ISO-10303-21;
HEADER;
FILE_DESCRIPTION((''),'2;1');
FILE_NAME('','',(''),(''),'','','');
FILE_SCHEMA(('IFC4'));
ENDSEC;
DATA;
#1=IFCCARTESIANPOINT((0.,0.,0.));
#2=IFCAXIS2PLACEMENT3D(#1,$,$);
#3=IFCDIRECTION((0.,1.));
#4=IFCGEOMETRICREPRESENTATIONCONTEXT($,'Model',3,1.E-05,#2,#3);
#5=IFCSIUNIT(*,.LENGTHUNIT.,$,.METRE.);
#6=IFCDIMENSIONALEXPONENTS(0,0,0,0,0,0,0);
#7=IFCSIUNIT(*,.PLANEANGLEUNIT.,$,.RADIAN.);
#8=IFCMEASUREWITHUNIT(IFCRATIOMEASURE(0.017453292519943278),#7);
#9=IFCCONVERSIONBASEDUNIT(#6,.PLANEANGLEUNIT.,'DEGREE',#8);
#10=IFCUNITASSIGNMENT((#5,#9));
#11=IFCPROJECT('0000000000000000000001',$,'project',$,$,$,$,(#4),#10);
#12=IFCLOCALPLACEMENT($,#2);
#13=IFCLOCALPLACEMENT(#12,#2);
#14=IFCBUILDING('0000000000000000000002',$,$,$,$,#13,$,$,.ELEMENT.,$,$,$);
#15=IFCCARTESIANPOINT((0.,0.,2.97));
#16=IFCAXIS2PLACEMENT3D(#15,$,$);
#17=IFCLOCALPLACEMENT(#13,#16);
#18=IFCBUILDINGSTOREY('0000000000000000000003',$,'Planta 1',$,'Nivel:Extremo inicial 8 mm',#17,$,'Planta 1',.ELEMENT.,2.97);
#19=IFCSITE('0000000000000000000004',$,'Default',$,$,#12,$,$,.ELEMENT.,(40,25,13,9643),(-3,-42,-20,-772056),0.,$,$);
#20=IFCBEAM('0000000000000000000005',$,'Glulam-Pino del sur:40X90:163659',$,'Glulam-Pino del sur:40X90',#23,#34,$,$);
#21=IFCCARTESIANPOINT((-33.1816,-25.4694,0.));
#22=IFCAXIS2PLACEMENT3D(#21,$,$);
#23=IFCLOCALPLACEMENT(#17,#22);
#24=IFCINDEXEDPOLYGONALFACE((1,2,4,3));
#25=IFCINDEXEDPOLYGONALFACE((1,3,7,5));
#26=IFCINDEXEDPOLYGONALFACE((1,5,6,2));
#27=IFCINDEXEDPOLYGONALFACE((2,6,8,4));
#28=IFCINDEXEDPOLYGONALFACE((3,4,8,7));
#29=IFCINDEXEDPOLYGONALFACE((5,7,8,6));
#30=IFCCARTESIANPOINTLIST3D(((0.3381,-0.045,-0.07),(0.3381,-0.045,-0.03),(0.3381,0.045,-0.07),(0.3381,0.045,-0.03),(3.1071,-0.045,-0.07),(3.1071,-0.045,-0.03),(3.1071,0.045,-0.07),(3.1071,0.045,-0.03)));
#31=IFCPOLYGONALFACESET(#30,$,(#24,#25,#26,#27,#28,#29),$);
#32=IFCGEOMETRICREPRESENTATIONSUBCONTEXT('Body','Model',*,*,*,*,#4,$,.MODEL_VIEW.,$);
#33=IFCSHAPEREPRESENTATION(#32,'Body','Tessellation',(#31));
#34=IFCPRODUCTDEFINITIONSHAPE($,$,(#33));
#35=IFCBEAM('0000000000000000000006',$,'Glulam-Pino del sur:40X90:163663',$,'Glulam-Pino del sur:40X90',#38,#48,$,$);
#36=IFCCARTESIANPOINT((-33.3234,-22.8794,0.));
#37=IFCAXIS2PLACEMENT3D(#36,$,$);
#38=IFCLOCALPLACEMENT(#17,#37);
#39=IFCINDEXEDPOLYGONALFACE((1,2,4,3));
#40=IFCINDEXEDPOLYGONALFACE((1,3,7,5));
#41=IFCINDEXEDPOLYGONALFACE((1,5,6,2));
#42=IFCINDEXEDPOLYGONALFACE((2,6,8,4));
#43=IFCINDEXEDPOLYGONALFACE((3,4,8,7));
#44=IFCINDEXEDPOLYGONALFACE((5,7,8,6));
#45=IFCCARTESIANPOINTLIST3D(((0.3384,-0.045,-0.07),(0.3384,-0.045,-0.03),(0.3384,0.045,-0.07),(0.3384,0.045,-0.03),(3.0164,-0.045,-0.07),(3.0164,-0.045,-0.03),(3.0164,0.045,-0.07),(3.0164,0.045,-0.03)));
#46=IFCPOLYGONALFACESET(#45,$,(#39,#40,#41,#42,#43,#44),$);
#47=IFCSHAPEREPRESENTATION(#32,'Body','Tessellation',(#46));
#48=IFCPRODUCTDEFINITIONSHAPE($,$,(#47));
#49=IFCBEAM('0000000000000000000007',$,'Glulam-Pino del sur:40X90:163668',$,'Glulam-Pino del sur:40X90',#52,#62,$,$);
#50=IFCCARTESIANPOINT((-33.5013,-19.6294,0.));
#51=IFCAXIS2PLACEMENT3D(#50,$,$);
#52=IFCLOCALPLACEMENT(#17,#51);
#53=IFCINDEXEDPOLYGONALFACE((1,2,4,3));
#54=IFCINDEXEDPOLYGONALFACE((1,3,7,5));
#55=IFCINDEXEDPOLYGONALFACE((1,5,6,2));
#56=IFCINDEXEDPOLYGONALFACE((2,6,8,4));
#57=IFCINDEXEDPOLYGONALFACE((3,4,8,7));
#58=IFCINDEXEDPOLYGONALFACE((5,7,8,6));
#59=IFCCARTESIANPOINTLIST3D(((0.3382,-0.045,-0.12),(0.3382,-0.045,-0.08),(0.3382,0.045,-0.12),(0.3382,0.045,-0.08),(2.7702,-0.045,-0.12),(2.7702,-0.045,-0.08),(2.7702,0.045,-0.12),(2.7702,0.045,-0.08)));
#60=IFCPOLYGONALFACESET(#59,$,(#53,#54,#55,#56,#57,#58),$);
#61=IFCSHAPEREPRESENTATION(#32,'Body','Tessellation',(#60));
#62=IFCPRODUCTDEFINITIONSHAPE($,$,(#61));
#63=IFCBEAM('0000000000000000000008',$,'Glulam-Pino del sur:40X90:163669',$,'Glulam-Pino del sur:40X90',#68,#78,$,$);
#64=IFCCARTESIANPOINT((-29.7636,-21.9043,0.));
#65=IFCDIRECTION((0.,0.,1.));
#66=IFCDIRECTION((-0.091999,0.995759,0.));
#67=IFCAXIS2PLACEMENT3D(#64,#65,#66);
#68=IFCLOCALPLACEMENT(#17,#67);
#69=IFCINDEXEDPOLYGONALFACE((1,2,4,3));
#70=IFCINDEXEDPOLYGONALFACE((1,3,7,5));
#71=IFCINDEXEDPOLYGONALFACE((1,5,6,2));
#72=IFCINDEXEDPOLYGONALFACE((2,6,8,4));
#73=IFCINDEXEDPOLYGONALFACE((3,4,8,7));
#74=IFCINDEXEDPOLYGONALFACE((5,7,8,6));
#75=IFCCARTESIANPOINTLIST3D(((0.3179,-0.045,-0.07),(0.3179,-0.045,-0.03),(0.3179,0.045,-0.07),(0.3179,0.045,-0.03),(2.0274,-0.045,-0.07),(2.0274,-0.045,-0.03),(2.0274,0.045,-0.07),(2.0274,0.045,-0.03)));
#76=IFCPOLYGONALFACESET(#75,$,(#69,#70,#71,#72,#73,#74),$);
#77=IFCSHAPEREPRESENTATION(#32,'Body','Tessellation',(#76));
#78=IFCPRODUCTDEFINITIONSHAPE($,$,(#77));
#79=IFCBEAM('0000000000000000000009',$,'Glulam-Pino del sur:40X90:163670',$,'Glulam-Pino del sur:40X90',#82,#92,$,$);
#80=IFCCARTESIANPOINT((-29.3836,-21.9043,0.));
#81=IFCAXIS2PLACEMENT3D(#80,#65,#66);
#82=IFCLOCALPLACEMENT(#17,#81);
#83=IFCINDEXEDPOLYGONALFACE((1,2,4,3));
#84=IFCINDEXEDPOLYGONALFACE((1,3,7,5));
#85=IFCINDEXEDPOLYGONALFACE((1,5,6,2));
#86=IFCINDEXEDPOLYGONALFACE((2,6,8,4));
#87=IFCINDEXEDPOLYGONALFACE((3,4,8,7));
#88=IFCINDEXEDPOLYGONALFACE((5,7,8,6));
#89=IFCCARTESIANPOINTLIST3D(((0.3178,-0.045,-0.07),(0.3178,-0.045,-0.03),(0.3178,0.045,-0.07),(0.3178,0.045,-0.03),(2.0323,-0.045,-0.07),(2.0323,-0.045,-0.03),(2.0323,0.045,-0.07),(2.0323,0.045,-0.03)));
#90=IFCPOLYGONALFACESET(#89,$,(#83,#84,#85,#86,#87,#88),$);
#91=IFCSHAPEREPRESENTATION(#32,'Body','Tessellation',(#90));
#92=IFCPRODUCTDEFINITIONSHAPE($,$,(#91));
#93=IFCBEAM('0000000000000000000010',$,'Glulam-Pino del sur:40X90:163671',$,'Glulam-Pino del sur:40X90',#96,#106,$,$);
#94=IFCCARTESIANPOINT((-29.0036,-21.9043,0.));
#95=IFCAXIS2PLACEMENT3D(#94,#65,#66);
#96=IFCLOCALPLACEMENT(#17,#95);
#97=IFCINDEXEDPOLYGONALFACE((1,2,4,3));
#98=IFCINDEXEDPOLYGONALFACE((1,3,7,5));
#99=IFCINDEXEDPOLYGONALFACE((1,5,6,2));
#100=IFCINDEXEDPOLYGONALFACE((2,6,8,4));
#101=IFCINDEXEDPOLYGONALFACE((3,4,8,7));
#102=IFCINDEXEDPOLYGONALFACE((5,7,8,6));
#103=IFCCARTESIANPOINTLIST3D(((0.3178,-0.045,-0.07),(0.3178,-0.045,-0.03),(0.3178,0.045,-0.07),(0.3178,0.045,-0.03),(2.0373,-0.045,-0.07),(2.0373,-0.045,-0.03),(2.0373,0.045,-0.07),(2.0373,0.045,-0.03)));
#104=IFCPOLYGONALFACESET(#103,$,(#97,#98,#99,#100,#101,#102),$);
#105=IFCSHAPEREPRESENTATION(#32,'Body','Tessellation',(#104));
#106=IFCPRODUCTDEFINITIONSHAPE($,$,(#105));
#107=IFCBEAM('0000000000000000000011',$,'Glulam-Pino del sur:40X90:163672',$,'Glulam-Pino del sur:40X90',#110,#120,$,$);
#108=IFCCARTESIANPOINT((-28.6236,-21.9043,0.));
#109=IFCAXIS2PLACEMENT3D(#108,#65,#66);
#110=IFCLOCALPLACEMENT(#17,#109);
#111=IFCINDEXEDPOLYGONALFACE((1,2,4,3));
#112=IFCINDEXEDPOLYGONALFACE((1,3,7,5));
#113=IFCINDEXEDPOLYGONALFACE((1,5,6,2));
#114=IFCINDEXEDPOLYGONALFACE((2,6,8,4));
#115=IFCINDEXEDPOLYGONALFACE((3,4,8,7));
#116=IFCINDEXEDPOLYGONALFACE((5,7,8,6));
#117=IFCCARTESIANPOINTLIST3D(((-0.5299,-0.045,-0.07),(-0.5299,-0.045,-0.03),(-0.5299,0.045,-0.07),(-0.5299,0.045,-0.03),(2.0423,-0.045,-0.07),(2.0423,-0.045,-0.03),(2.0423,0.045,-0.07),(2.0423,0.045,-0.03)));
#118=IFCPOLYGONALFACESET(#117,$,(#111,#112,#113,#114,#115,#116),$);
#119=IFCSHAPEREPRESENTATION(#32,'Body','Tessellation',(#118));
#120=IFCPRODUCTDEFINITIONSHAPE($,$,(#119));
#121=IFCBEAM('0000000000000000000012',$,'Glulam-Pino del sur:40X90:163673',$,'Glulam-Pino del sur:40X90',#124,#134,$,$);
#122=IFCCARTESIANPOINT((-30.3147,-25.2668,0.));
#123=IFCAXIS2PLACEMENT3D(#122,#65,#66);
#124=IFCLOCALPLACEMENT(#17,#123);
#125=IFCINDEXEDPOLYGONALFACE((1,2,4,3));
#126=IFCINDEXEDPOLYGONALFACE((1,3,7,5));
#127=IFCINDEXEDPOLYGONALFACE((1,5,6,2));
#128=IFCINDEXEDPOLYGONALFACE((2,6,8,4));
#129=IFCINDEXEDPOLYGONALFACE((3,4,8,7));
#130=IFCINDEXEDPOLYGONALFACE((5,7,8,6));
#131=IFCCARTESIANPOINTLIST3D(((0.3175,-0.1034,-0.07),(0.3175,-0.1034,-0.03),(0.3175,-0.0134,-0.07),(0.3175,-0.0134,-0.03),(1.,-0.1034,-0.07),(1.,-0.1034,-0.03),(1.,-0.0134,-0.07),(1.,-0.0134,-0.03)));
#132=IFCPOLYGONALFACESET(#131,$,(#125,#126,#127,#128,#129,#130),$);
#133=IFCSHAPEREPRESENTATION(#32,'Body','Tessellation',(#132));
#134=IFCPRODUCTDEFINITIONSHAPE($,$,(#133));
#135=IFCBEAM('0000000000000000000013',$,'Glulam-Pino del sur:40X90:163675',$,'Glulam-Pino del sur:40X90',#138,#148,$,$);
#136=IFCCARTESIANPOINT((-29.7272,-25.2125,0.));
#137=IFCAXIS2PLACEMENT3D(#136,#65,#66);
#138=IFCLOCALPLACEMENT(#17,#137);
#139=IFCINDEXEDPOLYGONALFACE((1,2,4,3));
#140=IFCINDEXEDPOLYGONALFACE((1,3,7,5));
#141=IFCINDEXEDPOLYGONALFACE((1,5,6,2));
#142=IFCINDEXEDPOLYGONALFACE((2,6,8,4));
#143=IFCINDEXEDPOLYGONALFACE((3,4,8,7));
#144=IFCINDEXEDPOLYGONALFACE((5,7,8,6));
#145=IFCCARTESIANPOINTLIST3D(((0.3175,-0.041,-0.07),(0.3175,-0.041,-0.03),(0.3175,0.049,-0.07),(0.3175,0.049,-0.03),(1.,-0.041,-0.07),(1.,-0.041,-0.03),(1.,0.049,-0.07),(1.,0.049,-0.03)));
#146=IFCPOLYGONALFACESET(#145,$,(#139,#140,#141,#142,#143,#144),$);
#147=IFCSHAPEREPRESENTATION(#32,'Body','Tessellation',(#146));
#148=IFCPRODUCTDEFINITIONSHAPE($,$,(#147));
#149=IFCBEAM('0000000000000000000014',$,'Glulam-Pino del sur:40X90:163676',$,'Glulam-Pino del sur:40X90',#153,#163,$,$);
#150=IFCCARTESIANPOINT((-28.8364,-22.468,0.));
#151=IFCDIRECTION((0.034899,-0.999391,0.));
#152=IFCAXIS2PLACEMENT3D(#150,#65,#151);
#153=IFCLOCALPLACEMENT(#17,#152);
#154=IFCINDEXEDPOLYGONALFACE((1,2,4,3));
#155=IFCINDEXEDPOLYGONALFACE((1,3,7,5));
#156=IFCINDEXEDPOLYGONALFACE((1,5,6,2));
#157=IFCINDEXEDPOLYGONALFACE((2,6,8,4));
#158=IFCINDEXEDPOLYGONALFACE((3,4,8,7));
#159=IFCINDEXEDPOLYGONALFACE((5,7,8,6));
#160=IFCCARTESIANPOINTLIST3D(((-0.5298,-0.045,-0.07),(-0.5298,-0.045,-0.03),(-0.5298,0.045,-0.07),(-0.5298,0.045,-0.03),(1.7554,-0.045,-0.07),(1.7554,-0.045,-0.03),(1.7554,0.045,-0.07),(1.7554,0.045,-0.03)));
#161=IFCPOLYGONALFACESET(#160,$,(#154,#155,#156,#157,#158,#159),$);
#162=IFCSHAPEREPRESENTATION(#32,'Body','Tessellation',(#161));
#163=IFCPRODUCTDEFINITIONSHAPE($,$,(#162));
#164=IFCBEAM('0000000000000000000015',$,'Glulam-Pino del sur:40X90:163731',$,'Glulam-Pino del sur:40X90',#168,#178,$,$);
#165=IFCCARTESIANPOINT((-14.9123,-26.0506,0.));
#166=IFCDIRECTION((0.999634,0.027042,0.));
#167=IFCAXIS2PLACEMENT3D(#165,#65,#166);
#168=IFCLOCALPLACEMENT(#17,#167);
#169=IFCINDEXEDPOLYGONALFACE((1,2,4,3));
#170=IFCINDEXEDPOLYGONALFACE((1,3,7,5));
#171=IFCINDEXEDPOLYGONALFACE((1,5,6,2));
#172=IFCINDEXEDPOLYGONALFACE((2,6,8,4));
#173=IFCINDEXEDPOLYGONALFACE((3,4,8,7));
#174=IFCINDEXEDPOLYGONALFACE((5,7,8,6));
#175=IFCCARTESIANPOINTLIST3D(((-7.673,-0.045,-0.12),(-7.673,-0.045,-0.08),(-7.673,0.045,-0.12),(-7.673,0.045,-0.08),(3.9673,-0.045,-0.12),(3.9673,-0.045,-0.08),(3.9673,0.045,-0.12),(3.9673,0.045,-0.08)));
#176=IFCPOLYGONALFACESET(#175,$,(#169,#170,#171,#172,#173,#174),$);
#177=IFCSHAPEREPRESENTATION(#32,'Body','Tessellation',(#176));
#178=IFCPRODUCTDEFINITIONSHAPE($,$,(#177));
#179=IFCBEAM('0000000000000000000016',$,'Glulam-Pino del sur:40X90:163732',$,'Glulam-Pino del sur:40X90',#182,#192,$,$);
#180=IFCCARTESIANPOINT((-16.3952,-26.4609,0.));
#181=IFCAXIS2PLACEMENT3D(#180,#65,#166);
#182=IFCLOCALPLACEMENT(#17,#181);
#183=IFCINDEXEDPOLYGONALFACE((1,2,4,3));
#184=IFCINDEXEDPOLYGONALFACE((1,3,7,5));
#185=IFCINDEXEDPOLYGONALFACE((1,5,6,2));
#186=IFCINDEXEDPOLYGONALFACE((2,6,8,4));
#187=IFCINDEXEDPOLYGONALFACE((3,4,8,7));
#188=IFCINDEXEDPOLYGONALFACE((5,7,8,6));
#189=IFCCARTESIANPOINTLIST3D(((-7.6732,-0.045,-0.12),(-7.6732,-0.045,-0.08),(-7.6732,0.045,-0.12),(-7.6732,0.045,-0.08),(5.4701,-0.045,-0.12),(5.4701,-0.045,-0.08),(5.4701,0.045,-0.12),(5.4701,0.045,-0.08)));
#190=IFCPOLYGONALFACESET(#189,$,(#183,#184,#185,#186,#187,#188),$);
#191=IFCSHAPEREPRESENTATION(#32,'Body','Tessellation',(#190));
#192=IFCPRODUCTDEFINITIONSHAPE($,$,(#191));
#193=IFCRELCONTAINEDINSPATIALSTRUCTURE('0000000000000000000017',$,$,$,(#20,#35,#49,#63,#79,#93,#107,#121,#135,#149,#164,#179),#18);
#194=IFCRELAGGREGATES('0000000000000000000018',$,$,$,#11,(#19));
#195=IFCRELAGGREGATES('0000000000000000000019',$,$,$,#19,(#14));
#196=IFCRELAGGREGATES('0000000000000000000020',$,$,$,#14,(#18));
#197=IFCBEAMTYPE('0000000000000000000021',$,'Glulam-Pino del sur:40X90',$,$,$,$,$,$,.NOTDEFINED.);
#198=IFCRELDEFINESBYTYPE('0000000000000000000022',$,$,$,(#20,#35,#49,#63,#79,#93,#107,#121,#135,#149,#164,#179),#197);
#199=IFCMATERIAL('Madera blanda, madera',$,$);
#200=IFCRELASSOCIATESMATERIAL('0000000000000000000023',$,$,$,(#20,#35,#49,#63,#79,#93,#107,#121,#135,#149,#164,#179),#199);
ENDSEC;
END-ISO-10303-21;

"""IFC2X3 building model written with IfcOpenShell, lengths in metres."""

from ifc_helpers import new_model, entity, si_unit, converted_unit, direction, frame, frame_2d, origin, place, context, subcontext, project, spatial, rectangle, extrude, material, type_object, element, save


model = new_model("IFC2X3")

# Units and contexts
model_context = context("Model", 3, precision=1e-05, world=origin(), true_north=direction((0.0, 1.0)))
body_context = subcontext(model_context, "Body", "Model", "MODEL_VIEW")
ifc_project = project(units=[si_unit("LENGTHUNIT", "METRE"), converted_unit("PLANEANGLEUNIT", "DEGREE", entity("IfcRatioMeasure", 0.017453292519943278), si_unit("PLANEANGLEUNIT", "RADIAN"), dimensions=[0, 0, 0, 0, 0, 0, 0])], contexts=[model_context])

# Site, building, storey
site_placement = place(None, origin())
site = spatial("IfcSite", under=ifc_project, at=site_placement, Name="Default", CompositionType="ELEMENT", RefLatitude=(40, 25, 13, 9643), RefLongitude=(-3, -42, -20, -772056), RefElevation=0.0)
building_placement = place(site_placement, origin())
building = spatial("IfcBuilding", under=site, at=building_placement, CompositionType="ELEMENT")
storey_placement = place(building_placement, frame((0.0, 0.0, 2.97)))
storey = spatial("IfcBuildingStorey", under=building, at=storey_placement, Name="Planta 1", ObjectType="Nivel:Extremo inicial 8 mm", LongName="Planta 1", CompositionType="ELEMENT", Elevation=2.97)

# Beams
ifc_material_1 = material(Name="Madera blanda, madera")
beam_type_1 = type_object("IfcBeamType", Name="Glulam-Pino del sur:40X90", PredefinedType="NOTDEFINED")
beam_1_placement = place(storey_placement, frame((-33.1816, -25.4694, 0.0)))
element("IfcBeam", 1, at=beam_1_placement, inside=storey, type_object=beam_type_1, material=ifc_material_1, Name="Glulam-Pino del sur:40X90:163659", ObjectType="Glulam-Pino del sur:40X90", context=body_context, shape_type="SweptSolid", body=[
    extrude(rectangle(XDim=0.04, YDim=0.09, at=frame_2d((0.0, 0.0), x_axis=(1.0, 0.0))), frame((0.3381, 0.0, -0.05), z_axis=(1.0, 0.0, 0.0), x_axis=(0.0, 0.0, -1.0)), (0.0, 0.0, 1.0), 2.769),
])
beam_2_placement = place(storey_placement, frame((-33.3234, -22.8794, 0.0)))
element("IfcBeam", 2, at=beam_2_placement, inside=storey, type_object=beam_type_1, material=ifc_material_1, Name="Glulam-Pino del sur:40X90:163663", ObjectType="Glulam-Pino del sur:40X90", context=body_context, shape_type="SweptSolid", body=[
    extrude(rectangle(XDim=0.04, YDim=0.09, at=frame_2d((0.0, 0.0), x_axis=(1.0, 0.0))), frame((0.3384, 0.0, -0.05), z_axis=(1.0, 0.0, 0.0), x_axis=(0.0, 0.0, -1.0)), (0.0, 0.0, 1.0), 2.678),
])
beam_3_placement = place(storey_placement, frame((-33.5013, -19.6294, 0.0)))
element("IfcBeam", 3, at=beam_3_placement, inside=storey, type_object=beam_type_1, material=ifc_material_1, Name="Glulam-Pino del sur:40X90:163668", ObjectType="Glulam-Pino del sur:40X90", context=body_context, shape_type="SweptSolid", body=[
    extrude(rectangle(XDim=0.04, YDim=0.09, at=frame_2d((0.0, 0.0), x_axis=(1.0, 0.0))), frame((0.3382, 0.0, -0.1), z_axis=(1.0, 0.0, 0.0), x_axis=(0.0, 0.0, -1.0)), (0.0, 0.0, 1.0), 2.432),
])
beam_4_placement = place(storey_placement, frame((-29.7636, -21.9043, 0.0), z_axis=(0.0, 0.0, 1.0), x_axis=(-0.091999, 0.995759, 0.0)))
element("IfcBeam", 4, at=beam_4_placement, inside=storey, type_object=beam_type_1, material=ifc_material_1, Name="Glulam-Pino del sur:40X90:163669", ObjectType="Glulam-Pino del sur:40X90", context=body_context, shape_type="SweptSolid", body=[
    extrude(rectangle(XDim=0.04, YDim=0.09, at=frame_2d((0.0, 0.0), x_axis=(1.0, 0.0))), frame((0.3179, 0.0, -0.05), z_axis=(1.0, 0.0, 0.0), x_axis=(0.0, 0.0, -1.0)), (0.0, 0.0, 1.0), 1.7095),
])
beam_5_placement = place(storey_placement, frame((-29.3836, -21.9043, 0.0), z_axis=(0.0, 0.0, 1.0), x_axis=(-0.091999, 0.995759, 0.0)))
element("IfcBeam", 5, at=beam_5_placement, inside=storey, type_object=beam_type_1, material=ifc_material_1, Name="Glulam-Pino del sur:40X90:163670", ObjectType="Glulam-Pino del sur:40X90", context=body_context, shape_type="SweptSolid", body=[
    extrude(rectangle(XDim=0.04, YDim=0.09, at=frame_2d((0.0, 0.0), x_axis=(1.0, 0.0))), frame((0.3178, 0.0, -0.05), z_axis=(1.0, 0.0, 0.0), x_axis=(0.0, 0.0, -1.0)), (0.0, 0.0, 1.0), 1.7145),
])
beam_6_placement = place(storey_placement, frame((-29.0036, -21.9043, 0.0), z_axis=(0.0, 0.0, 1.0), x_axis=(-0.091999, 0.995759, 0.0)))
element("IfcBeam", 6, at=beam_6_placement, inside=storey, type_object=beam_type_1, material=ifc_material_1, Name="Glulam-Pino del sur:40X90:163671", ObjectType="Glulam-Pino del sur:40X90", context=body_context, shape_type="SweptSolid", body=[
    extrude(rectangle(XDim=0.04, YDim=0.09, at=frame_2d((0.0, 0.0), x_axis=(1.0, 0.0))), frame((0.3178, 0.0, -0.05), z_axis=(1.0, 0.0, 0.0), x_axis=(0.0, 0.0, -1.0)), (0.0, 0.0, 1.0), 1.7195),
])
beam_7_placement = place(storey_placement, frame((-28.6236, -21.9043, 0.0), z_axis=(0.0, 0.0, 1.0), x_axis=(-0.091999, 0.995759, 0.0)))
element("IfcBeam", 7, at=beam_7_placement, inside=storey, type_object=beam_type_1, material=ifc_material_1, Name="Glulam-Pino del sur:40X90:163672", ObjectType="Glulam-Pino del sur:40X90", context=body_context, shape_type="SweptSolid", body=[
    extrude(rectangle(XDim=0.04, YDim=0.09, at=frame_2d((0.0, 0.0), x_axis=(1.0, 0.0))), frame((-0.5299, 0.0, -0.05), z_axis=(1.0, 0.0, 0.0), x_axis=(0.0, 0.0, -1.0)), (0.0, 0.0, 1.0), 2.5722),
])
beam_8_placement = place(storey_placement, frame((-30.3147, -25.2668, 0.0), z_axis=(0.0, 0.0, 1.0), x_axis=(-0.091999, 0.995759, 0.0)))
element("IfcBeam", 8, at=beam_8_placement, inside=storey, type_object=beam_type_1, material=ifc_material_1, Name="Glulam-Pino del sur:40X90:163673", ObjectType="Glulam-Pino del sur:40X90", context=body_context, shape_type="SweptSolid", body=[
    extrude(rectangle(XDim=0.04, YDim=0.09, at=frame_2d((0.0, 0.0), x_axis=(1.0, 0.0))), frame((0.3175, -0.0584, -0.05), z_axis=(1.0, 0.0, 0.0), x_axis=(0.0, 0.0, -1.0)), (0.0, 0.0, 1.0), 0.6825),
])
beam_9_placement = place(storey_placement, frame((-29.7272, -25.2125, 0.0), z_axis=(0.0, 0.0, 1.0), x_axis=(-0.091999, 0.995759, 0.0)))
element("IfcBeam", 9, at=beam_9_placement, inside=storey, type_object=beam_type_1, material=ifc_material_1, Name="Glulam-Pino del sur:40X90:163675", ObjectType="Glulam-Pino del sur:40X90", context=body_context, shape_type="SweptSolid", body=[
    extrude(rectangle(XDim=0.04, YDim=0.09, at=frame_2d((0.0, 0.0), x_axis=(1.0, 0.0))), frame((0.3175, 0.004, -0.05), z_axis=(1.0, 0.0, 0.0), x_axis=(0.0, 0.0, -1.0)), (0.0, 0.0, 1.0), 0.6825),
])
beam_10_placement = place(storey_placement, frame((-28.8364, -22.468, 0.0), z_axis=(0.0, 0.0, 1.0), x_axis=(0.034899, -0.999391, 0.0)))
element("IfcBeam", 10, at=beam_10_placement, inside=storey, type_object=beam_type_1, material=ifc_material_1, Name="Glulam-Pino del sur:40X90:163676", ObjectType="Glulam-Pino del sur:40X90", context=body_context, shape_type="SweptSolid", body=[
    extrude(rectangle(XDim=0.04, YDim=0.09, at=frame_2d((0.0, 0.0), x_axis=(1.0, 0.0))), frame((-0.5298, 0.0, -0.05), z_axis=(1.0, 0.0, 0.0), x_axis=(0.0, 0.0, -1.0)), (0.0, 0.0, 1.0), 2.2852),
])
beam_11_placement = place(storey_placement, frame((-14.9123, -26.0506, 0.0), z_axis=(0.0, 0.0, 1.0), x_axis=(0.999634, 0.027042, 0.0)))
element("IfcBeam", 11, at=beam_11_placement, inside=storey, type_object=beam_type_1, material=ifc_material_1, Name="Glulam-Pino del sur:40X90:163731", ObjectType="Glulam-Pino del sur:40X90", context=body_context, shape_type="SweptSolid", body=[
    extrude(rectangle(XDim=0.04, YDim=0.09, at=frame_2d((0.0, 0.0), x_axis=(1.0, 0.0))), frame((-7.673, 0.0, -0.1), z_axis=(1.0, 0.0, 0.0), x_axis=(0.0, 0.0, -1.0)), (0.0, 0.0, 1.0), 11.6403),
])
beam_12_placement = place(storey_placement, frame((-16.3952, -26.4609, 0.0), z_axis=(0.0, 0.0, 1.0), x_axis=(0.999634, 0.027042, 0.0)))
element("IfcBeam", 12, at=beam_12_placement, inside=storey, type_object=beam_type_1, material=ifc_material_1, Name="Glulam-Pino del sur:40X90:163732", ObjectType="Glulam-Pino del sur:40X90", context=body_context, shape_type="SweptSolid", body=[
    extrude(rectangle(XDim=0.04, YDim=0.09, at=frame_2d((0.0, 0.0), x_axis=(1.0, 0.0))), frame((-7.6732, 0.0, -0.1), z_axis=(1.0, 0.0, 0.0), x_axis=(0.0, 0.0, -1.0)), (0.0, 0.0, 1.0), 13.1433),
])

save(model, "model.ifc")
